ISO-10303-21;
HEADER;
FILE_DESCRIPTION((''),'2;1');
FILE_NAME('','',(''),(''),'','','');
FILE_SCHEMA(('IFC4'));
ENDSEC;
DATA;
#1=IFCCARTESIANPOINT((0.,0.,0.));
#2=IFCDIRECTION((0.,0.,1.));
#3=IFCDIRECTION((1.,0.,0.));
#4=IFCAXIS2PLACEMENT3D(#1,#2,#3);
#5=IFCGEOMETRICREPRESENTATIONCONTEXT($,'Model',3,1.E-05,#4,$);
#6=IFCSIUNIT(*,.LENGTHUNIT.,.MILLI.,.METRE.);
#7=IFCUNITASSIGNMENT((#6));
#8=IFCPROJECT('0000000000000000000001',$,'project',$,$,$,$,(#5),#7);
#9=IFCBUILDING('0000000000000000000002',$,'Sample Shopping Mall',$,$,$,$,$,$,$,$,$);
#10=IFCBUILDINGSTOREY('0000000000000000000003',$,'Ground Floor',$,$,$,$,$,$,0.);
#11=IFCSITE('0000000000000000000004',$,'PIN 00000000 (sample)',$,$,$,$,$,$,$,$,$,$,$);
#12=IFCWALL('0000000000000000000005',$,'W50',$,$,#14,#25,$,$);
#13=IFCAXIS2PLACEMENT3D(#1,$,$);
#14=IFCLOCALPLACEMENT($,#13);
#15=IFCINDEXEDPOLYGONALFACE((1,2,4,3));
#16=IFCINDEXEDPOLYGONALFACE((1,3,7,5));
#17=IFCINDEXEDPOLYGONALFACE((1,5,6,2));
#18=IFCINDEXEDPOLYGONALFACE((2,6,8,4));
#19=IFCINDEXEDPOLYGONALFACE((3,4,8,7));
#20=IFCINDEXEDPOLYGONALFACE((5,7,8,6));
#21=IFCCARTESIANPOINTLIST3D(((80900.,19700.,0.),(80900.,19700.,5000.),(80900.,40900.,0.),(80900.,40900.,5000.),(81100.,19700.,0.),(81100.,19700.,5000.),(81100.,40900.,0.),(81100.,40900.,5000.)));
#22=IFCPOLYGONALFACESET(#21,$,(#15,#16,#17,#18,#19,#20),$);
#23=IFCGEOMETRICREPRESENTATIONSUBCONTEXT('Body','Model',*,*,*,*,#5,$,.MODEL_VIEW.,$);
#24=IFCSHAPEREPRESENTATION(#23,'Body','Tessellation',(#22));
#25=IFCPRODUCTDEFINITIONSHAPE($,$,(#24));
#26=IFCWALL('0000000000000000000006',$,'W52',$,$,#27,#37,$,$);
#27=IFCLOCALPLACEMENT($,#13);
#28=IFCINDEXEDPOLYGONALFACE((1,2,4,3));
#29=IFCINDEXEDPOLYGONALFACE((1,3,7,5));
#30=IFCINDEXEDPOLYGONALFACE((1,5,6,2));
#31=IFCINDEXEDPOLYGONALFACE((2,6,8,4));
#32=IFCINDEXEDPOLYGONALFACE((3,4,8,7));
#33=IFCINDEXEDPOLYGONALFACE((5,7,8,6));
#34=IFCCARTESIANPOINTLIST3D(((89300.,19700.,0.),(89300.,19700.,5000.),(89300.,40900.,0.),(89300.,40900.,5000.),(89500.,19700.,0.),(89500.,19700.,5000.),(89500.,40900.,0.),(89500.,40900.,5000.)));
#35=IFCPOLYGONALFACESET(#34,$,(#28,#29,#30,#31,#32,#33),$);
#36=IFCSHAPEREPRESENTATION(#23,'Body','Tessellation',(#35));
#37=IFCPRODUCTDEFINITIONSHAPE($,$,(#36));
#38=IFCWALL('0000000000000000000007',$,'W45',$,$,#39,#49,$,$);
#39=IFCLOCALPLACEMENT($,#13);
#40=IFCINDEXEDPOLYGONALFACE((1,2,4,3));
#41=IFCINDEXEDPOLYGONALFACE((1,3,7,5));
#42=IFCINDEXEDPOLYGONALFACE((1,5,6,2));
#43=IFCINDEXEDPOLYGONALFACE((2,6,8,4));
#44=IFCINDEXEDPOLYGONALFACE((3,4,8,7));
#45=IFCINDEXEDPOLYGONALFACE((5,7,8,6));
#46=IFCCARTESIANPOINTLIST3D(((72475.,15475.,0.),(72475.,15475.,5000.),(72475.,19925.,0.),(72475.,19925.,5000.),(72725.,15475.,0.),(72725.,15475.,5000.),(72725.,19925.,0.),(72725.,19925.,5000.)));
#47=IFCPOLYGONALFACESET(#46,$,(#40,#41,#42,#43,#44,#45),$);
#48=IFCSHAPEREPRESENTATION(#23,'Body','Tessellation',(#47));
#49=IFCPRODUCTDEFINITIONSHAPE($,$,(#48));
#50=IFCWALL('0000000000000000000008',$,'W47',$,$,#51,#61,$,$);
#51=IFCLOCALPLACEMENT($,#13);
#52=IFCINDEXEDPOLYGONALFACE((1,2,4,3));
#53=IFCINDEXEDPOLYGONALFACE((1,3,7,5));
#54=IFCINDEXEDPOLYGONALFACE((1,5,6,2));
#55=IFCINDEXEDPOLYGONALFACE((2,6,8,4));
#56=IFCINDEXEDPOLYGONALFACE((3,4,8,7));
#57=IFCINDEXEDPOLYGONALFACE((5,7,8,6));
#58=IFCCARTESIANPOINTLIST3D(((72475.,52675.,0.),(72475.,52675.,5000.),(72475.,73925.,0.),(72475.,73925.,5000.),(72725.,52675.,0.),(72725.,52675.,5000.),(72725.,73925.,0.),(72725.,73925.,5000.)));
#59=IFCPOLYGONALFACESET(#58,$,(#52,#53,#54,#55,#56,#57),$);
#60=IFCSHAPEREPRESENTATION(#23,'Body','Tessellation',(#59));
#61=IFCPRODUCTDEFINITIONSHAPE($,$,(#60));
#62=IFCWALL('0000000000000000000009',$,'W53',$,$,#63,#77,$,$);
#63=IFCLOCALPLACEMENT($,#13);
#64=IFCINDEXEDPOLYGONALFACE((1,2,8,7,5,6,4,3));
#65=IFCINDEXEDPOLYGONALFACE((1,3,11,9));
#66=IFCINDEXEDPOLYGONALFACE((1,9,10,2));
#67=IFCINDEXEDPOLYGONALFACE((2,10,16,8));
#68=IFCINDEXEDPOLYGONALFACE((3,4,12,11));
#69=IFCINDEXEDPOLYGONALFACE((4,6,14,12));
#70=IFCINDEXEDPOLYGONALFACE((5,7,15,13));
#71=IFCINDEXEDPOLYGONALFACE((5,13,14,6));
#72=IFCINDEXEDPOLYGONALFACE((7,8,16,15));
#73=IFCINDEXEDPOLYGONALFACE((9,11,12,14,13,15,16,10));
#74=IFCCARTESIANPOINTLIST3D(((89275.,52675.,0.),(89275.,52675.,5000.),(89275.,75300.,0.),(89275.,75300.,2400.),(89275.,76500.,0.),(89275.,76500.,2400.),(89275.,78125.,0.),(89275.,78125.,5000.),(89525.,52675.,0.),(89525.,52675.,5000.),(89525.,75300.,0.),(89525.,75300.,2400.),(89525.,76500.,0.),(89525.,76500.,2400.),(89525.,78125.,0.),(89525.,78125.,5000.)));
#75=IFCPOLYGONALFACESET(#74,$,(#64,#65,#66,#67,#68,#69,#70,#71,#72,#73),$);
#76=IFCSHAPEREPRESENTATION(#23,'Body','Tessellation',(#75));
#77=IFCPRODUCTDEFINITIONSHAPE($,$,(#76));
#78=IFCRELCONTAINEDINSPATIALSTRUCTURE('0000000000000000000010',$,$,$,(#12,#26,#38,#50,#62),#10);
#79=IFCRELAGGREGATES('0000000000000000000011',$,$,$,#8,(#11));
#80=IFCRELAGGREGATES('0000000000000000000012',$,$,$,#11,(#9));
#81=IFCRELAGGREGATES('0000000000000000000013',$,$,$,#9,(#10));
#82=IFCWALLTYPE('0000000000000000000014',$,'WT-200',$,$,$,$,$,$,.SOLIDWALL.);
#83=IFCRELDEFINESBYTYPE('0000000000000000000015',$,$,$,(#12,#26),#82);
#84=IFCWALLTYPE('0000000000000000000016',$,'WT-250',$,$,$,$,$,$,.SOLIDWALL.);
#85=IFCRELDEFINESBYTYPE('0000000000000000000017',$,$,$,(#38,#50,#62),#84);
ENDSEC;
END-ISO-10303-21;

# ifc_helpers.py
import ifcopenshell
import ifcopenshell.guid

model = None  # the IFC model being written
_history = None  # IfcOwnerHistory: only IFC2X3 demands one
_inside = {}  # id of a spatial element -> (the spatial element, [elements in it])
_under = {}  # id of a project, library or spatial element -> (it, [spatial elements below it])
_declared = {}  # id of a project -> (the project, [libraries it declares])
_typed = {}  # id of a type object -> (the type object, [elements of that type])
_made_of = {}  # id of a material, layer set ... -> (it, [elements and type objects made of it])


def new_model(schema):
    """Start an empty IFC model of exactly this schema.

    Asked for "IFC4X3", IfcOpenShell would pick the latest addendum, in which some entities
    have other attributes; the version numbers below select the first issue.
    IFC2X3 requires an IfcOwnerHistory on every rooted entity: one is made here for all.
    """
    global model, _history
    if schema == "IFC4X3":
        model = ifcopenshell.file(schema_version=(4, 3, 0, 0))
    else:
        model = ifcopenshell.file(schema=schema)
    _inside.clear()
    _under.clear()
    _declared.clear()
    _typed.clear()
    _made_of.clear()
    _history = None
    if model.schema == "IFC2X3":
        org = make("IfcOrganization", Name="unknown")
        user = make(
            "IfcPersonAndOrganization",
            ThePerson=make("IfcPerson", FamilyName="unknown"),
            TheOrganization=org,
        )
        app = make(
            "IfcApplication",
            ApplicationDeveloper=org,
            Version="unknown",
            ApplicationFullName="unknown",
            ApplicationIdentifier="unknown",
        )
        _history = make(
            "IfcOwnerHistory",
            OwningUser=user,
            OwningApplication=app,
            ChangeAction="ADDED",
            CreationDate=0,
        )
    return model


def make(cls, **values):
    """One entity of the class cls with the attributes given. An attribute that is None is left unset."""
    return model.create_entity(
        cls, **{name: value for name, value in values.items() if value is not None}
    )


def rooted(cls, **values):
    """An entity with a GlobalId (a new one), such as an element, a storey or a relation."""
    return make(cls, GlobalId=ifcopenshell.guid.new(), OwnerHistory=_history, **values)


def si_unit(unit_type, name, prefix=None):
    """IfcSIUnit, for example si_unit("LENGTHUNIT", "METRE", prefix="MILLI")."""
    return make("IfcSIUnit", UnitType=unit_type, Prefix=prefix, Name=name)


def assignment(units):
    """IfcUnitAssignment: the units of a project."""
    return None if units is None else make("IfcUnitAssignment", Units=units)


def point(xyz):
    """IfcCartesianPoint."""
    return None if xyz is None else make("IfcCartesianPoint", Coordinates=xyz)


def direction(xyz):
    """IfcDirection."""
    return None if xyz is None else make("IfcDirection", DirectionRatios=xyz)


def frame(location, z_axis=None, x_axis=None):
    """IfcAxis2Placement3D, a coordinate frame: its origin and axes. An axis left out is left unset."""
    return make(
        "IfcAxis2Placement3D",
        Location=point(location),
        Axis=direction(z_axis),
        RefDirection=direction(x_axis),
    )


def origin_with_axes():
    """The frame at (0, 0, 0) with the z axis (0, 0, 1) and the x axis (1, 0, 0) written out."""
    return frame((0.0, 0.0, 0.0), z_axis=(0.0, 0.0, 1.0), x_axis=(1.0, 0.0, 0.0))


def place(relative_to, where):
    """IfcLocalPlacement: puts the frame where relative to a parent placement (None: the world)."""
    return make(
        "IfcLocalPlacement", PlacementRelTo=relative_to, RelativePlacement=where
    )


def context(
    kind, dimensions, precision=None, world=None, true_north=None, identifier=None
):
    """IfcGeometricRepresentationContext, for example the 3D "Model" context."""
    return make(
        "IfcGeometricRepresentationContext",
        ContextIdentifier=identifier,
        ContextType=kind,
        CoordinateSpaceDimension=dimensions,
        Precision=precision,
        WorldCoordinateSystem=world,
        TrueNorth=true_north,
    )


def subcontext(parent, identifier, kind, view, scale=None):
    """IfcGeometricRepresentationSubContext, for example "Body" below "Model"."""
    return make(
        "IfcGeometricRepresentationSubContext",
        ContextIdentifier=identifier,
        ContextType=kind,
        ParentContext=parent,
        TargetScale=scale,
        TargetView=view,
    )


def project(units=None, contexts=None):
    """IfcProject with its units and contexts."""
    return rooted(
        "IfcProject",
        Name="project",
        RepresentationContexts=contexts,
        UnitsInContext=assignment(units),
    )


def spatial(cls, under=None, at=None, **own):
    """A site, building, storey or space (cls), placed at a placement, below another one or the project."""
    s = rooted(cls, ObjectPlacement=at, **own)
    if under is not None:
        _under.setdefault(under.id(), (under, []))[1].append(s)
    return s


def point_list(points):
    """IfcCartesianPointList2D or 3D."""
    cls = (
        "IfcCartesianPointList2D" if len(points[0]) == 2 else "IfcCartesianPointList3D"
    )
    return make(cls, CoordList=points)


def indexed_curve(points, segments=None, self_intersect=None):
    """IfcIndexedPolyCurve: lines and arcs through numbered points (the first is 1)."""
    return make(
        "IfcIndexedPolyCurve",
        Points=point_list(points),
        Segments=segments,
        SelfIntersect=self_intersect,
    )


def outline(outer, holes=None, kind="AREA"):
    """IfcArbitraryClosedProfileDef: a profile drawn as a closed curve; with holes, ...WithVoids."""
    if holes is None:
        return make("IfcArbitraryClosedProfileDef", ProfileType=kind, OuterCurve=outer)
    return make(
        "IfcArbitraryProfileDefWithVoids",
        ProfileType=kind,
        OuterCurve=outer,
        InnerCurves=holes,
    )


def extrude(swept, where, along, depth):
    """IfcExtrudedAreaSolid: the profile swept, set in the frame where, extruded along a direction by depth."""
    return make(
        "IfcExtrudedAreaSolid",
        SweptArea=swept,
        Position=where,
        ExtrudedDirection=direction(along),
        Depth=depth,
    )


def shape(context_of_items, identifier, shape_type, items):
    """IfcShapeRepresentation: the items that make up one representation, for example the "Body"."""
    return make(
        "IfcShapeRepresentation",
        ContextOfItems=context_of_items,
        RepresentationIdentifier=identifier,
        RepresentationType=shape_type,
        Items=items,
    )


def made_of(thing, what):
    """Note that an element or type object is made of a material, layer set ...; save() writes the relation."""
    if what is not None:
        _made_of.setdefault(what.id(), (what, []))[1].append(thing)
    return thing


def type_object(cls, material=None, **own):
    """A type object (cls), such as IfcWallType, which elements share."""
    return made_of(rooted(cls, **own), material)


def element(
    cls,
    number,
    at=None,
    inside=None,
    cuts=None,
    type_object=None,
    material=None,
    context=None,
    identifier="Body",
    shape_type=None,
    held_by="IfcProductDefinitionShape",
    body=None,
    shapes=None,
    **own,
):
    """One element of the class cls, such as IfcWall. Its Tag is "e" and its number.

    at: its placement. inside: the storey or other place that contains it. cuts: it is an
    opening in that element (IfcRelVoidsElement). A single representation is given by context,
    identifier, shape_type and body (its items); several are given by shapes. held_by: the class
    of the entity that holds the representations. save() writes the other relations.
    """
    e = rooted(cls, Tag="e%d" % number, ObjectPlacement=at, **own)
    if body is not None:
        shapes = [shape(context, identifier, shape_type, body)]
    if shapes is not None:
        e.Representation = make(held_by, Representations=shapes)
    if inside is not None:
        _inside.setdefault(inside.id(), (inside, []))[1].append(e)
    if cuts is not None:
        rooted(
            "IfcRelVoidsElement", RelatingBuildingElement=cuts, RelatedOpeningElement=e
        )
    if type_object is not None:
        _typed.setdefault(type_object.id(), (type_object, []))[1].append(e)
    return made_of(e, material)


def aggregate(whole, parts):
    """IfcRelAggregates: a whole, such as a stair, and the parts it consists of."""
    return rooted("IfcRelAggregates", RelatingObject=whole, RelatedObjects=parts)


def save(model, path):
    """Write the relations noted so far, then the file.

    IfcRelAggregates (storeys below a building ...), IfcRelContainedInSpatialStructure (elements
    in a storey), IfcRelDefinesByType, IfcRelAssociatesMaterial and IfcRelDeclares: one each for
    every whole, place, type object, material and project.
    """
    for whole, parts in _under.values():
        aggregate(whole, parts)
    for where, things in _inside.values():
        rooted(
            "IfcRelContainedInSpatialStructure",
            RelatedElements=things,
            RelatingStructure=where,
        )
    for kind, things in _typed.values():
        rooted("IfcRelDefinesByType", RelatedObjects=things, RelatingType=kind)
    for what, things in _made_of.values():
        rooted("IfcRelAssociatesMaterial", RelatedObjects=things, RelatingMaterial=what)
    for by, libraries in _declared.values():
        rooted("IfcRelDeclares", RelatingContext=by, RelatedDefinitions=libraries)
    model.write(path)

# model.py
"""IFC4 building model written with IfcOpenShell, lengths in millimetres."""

from ifc_helpers import new_model, si_unit, frame, origin_with_axes, place, context, subcontext, project, spatial, indexed_curve, outline, extrude, type_object, element, save


model = new_model("IFC4")

# Units and contexts
model_context = context("Model", 3, precision=1e-05, world=origin_with_axes())
body_context = subcontext(model_context, "Body", "Model", "MODEL_VIEW")
ifc_project = project(units=[si_unit("LENGTHUNIT", "METRE", prefix="MILLI")], contexts=[model_context])

# Site, building, storey
site = spatial("IfcSite", under=ifc_project, Name="PIN 00000000 (sample)")
building = spatial("IfcBuilding", under=site, Name="Sample Shopping Mall")
storey = spatial("IfcBuildingStorey", under=building, Name="Ground Floor", Elevation=0.0)

# Walls
wall_type_1 = type_object("IfcWallType", Name="WT-200", PredefinedType="SOLIDWALL")
for number, where, z_axis, x_axis, name in (
    (1, (81100.0, 19700.0, 0.0), (0.0, 0.0, 1.0), (0.0, 1.0, 0.0), "W50"),
    (2, (89500.0, 19700.0, 0.0), (0.0, 0.0, 1.0), (0.0, 1.0, 0.0), "W52"),
):
    element("IfcWall", number, at=place(None, frame(where, z_axis=z_axis, x_axis=x_axis)), inside=storey, type_object=wall_type_1, Name=name, context=body_context, shape_type="SweptSolid", body=[
        extrude(outline(indexed_curve([(0.0, 0.0), (0.0, 200.0), (21200.0, 200.0), (21200.0, 0.0), (0.0, 0.0)], self_intersect=False)), origin_with_axes(), (0.0, 0.0, 1.0), 5000.0),
    ])

# Shared definitions
wall_type_2 = type_object("IfcWallType", Name="WT-250", PredefinedType="SOLIDWALL")

# Walls
wall_1_placement = place(None, frame((72725.0, 15475.0, 0.0), z_axis=(0.0, 0.0, 1.0), x_axis=(0.0, 1.0, 0.0)))
element("IfcWall", 3, at=wall_1_placement, inside=storey, type_object=wall_type_2, Name="W45", context=body_context, shape_type="SweptSolid", body=[
    extrude(outline(indexed_curve([(0.0, 0.0), (0.0, 250.0), (4450.0, 250.0), (4450.0, 0.0), (0.0, 0.0)], self_intersect=False)), origin_with_axes(), (0.0, 0.0, 1.0), 5000.0),
])
wall_2_placement = place(None, frame((72725.0, 52675.0, 0.0), z_axis=(0.0, 0.0, 1.0), x_axis=(0.0, 1.0, 0.0)))
element("IfcWall", 4, at=wall_2_placement, inside=storey, type_object=wall_type_2, Name="W47", context=body_context, shape_type="SweptSolid", body=[
    extrude(outline(indexed_curve([(0.0, 0.0), (0.0, 250.0), (21250.0, 250.0), (21250.0, 0.0), (0.0, 0.0)], self_intersect=False)), origin_with_axes(), (0.0, 0.0, 1.0), 5000.0),
])

# Wall, opening
wall_3_placement = place(None, frame((89525.0, 52675.0, 0.0), z_axis=(0.0, 0.0, 1.0), x_axis=(0.0, 1.0, 0.0)))
wall_3 = element("IfcWall", 5, at=wall_3_placement, inside=storey, type_object=wall_type_2, Name="W53", context=body_context, shape_type="SweptSolid", body=[
    extrude(outline(indexed_curve([(0.0, 0.0), (0.0, 250.0), (25450.0, 250.0), (25450.0, 0.0), (0.0, 0.0)], self_intersect=False)), origin_with_axes(), (0.0, 0.0, 1.0), 5000.0),
])
opening_1_placement = place(wall_3_placement, frame((22625.0, -100.0, 0.0), z_axis=(0.0, 0.0, 1.0), x_axis=(1.0, 0.0, 0.0)))
element("IfcOpeningElement", 6, at=opening_1_placement, cuts=wall_3, context=body_context, shape_type="SweptSolid", body=[
    extrude(outline(indexed_curve([(0.0, 0.0), (0.0, 450.0), (1200.0, 450.0), (1200.0, 0.0), (0.0, 0.0)], self_intersect=False)), origin_with_axes(), (0.0, 0.0, 1.0), 2400.0),
])

save(model, "model.ifc")
